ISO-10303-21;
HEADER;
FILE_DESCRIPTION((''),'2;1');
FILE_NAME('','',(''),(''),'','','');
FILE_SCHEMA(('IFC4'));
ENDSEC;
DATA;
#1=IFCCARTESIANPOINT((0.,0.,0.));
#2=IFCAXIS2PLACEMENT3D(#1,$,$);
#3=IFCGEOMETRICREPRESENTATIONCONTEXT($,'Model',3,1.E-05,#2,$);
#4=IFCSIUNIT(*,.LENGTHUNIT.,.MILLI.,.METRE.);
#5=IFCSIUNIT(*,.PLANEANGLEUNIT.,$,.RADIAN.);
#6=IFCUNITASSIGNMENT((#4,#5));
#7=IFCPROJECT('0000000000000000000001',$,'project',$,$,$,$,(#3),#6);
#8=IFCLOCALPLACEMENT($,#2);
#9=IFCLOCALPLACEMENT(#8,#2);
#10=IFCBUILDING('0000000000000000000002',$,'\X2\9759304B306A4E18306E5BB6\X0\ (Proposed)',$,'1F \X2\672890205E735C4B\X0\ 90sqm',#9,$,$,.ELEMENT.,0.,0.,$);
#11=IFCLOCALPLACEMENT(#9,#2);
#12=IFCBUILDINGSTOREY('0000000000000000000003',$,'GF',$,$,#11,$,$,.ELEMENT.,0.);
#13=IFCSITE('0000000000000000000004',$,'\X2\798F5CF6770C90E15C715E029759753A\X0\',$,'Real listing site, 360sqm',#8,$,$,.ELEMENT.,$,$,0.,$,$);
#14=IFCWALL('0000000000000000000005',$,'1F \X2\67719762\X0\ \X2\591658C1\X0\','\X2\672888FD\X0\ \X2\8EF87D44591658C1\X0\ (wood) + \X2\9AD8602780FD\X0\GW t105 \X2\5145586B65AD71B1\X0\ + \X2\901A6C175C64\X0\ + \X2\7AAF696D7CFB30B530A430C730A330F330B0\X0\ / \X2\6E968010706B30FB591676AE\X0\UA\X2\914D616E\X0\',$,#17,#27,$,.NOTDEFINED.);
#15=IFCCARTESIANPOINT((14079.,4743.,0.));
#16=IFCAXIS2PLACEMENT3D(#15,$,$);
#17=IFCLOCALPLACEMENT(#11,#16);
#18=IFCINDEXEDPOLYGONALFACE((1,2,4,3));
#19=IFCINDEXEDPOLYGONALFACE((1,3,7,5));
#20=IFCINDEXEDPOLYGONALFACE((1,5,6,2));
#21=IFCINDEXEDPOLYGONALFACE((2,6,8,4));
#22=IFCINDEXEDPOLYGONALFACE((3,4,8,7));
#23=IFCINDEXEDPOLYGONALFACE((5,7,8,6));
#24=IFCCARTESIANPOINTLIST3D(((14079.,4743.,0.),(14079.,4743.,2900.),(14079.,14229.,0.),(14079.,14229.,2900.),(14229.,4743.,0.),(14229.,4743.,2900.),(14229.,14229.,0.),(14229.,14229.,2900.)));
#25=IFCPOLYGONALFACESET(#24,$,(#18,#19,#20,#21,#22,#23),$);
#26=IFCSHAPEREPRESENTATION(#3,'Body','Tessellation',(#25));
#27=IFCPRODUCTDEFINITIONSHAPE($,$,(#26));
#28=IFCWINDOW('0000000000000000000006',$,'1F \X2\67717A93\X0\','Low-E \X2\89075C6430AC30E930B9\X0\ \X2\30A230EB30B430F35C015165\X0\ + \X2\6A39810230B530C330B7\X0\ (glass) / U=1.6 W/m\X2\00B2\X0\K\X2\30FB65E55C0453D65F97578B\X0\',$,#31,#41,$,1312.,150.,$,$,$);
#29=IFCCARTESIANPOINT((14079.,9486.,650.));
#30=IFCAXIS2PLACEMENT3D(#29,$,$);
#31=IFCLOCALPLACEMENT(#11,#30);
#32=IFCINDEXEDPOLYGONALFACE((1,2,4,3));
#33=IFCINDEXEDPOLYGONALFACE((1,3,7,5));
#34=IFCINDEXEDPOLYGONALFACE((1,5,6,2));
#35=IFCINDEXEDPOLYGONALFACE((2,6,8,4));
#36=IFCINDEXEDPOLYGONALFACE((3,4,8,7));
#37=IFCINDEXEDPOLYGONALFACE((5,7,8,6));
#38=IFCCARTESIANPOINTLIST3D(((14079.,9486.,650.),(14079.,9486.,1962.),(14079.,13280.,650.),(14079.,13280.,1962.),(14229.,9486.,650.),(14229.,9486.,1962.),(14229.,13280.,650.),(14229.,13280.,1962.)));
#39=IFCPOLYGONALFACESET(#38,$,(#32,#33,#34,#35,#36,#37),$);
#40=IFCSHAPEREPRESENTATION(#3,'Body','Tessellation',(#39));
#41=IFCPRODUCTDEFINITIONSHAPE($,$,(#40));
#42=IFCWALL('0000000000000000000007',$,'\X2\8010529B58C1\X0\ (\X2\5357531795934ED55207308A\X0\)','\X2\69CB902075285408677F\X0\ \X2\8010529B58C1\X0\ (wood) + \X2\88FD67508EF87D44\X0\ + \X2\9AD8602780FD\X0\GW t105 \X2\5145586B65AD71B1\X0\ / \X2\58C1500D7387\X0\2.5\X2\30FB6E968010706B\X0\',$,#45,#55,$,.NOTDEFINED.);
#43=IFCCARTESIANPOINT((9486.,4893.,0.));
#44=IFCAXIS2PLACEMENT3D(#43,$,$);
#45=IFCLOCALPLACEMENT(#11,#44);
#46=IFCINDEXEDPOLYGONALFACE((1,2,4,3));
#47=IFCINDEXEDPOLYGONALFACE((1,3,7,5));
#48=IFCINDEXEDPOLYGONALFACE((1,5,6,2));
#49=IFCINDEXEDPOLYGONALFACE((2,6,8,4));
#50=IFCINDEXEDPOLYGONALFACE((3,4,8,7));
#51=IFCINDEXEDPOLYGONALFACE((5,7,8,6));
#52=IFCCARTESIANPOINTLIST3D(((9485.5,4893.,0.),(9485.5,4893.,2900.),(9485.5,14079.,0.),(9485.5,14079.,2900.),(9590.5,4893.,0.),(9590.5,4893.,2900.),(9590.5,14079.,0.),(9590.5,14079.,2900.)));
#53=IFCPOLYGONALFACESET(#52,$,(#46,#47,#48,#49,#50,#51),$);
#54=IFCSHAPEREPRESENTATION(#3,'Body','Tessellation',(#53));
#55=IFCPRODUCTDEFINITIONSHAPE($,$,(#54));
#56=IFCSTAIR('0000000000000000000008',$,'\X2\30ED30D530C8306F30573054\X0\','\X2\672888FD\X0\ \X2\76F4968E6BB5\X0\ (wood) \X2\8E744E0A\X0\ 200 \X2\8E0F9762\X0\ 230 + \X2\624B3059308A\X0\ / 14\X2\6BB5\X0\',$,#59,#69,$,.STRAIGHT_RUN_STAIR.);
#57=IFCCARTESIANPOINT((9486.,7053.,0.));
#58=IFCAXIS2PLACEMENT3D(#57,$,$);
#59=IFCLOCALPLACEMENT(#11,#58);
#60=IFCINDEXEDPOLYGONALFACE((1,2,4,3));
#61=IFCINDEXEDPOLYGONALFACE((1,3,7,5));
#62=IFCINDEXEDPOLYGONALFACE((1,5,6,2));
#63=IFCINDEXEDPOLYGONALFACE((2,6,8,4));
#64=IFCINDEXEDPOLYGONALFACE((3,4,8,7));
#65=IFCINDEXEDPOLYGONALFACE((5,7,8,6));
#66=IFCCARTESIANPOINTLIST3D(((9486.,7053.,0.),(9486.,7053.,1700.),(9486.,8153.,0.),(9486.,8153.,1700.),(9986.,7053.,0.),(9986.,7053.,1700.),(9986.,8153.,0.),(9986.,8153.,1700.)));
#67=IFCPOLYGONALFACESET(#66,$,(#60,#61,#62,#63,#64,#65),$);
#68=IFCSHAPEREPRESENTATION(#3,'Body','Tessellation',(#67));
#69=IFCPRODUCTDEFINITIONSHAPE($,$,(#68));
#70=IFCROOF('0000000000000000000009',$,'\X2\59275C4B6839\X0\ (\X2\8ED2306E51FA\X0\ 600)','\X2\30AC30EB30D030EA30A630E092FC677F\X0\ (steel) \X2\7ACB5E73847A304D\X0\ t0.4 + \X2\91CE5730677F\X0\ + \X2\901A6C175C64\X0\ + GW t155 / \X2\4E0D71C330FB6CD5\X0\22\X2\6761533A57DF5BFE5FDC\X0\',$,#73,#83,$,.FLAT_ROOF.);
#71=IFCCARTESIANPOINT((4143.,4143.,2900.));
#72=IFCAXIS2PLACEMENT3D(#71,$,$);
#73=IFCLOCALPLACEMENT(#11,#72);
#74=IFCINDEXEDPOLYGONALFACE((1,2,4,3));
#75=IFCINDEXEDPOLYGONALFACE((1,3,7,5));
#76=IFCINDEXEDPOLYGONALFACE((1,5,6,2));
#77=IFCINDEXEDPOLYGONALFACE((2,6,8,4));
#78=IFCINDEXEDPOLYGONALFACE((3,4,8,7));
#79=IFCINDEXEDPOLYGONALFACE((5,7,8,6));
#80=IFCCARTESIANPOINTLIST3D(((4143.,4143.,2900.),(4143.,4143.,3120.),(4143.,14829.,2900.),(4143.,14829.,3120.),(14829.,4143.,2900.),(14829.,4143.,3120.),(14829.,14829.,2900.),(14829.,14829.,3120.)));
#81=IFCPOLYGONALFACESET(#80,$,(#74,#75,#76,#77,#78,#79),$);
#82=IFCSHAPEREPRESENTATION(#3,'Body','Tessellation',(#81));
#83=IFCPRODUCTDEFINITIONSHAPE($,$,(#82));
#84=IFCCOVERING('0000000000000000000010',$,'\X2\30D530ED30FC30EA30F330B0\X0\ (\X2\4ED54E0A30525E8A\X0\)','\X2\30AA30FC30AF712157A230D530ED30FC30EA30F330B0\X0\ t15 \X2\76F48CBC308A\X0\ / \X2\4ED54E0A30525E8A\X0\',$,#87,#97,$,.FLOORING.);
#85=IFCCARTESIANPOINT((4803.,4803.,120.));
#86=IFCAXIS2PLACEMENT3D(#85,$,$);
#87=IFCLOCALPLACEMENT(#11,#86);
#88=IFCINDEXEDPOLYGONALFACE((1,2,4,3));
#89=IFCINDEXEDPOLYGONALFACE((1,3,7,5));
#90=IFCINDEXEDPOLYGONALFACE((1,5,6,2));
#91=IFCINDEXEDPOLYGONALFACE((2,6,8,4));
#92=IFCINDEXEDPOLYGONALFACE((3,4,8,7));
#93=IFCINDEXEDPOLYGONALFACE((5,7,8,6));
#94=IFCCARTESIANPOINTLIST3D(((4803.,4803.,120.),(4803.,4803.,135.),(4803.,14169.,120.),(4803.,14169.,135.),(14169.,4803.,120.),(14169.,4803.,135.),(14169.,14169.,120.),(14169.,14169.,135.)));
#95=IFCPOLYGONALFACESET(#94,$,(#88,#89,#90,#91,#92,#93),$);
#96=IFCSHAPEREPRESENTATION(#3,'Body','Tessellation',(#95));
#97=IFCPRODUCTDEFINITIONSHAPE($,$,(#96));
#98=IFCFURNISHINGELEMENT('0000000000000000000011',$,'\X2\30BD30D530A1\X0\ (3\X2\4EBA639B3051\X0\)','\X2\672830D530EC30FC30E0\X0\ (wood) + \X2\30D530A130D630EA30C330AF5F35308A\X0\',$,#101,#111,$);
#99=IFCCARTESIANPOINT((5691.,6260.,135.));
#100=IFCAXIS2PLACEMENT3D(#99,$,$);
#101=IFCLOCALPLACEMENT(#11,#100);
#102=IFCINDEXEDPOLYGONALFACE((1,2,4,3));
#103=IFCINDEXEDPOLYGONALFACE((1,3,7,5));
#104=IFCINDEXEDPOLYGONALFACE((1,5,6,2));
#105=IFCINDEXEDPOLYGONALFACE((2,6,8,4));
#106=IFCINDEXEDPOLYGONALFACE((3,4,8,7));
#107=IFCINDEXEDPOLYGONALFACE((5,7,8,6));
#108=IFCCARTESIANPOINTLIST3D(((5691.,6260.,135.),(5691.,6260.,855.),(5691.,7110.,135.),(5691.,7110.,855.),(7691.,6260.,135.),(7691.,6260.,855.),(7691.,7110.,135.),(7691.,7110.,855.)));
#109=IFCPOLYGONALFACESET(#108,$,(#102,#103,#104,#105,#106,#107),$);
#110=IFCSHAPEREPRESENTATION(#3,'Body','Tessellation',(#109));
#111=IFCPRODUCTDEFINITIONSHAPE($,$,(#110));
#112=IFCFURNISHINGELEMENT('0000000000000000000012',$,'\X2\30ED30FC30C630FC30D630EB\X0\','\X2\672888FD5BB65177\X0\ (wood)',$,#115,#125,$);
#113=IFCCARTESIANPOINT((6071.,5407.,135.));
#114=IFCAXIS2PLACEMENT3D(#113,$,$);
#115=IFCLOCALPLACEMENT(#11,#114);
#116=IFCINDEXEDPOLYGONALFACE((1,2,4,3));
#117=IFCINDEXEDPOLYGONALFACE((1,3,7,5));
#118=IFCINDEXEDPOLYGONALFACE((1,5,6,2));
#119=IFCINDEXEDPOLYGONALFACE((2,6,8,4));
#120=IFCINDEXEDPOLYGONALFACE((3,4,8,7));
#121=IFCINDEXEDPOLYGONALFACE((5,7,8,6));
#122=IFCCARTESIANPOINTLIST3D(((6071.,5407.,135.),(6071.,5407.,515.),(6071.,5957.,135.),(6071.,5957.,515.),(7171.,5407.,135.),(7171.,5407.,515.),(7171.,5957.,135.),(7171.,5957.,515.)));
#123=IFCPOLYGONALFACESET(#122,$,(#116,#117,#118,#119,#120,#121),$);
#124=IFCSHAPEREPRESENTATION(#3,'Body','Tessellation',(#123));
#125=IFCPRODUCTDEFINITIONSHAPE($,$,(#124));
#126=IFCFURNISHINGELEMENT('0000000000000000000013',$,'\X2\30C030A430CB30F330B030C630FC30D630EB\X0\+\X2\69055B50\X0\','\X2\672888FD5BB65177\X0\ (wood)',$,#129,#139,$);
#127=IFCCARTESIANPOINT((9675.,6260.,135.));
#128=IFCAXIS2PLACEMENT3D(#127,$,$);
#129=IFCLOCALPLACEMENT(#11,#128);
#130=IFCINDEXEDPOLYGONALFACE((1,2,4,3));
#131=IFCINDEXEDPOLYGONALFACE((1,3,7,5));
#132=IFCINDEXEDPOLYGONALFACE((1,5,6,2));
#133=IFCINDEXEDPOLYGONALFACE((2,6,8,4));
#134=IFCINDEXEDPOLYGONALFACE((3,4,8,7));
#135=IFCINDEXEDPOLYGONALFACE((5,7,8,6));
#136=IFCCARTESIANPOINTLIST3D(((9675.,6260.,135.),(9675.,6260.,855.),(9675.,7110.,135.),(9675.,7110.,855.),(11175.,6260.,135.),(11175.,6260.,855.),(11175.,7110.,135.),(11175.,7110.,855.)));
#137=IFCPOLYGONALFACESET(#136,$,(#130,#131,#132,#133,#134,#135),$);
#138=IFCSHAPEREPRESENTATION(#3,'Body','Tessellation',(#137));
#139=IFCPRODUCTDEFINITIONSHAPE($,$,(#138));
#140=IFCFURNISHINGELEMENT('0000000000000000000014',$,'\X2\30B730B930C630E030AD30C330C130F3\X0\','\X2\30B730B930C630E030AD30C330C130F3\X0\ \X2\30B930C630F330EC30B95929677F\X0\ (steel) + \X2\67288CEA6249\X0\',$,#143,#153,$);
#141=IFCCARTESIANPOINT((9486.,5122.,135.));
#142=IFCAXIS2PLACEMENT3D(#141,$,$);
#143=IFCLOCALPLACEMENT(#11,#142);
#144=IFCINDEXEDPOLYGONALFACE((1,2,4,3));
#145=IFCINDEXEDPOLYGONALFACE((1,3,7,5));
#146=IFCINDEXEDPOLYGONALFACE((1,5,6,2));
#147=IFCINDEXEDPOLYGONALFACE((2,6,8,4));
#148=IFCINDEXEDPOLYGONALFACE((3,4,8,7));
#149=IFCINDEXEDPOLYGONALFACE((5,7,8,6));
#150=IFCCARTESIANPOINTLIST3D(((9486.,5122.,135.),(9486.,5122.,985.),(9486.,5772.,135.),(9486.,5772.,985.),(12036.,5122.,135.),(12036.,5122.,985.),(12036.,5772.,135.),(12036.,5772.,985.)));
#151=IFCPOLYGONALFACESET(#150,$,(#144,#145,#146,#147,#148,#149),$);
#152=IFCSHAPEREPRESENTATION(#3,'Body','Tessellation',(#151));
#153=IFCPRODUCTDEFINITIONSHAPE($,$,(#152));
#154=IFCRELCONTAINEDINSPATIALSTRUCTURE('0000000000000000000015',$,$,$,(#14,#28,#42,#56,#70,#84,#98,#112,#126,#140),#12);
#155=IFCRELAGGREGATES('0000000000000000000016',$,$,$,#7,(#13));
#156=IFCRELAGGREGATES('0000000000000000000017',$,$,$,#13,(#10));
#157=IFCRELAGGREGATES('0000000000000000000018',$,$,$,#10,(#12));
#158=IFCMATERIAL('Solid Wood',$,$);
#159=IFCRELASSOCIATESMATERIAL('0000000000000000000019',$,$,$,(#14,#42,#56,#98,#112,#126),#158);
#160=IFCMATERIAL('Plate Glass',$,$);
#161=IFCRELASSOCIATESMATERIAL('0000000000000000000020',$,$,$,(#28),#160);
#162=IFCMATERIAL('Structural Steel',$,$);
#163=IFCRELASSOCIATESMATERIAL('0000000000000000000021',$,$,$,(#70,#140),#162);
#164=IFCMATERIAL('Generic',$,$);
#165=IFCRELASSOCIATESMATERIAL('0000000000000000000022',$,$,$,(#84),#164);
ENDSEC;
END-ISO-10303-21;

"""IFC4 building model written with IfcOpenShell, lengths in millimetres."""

from ifc_helpers import new_model, si_unit, frame, frame_2d, origin, place, context, project, spatial, rectangle, extrude, material, element, fill, save


model = new_model("IFC4")

# Units and contexts
model_context = context("Model", 3, precision=1e-05, world=origin())
ifc_project = project(units=[si_unit("LENGTHUNIT", "METRE", prefix="MILLI"), si_unit("PLANEANGLEUNIT", "RADIAN")], contexts=[model_context])

# Site, building, storey
site_placement = place(None, origin())
site = spatial("IfcSite", under=ifc_project, at=site_placement, Name="福島県郡山市静町", ObjectType="Real listing site, 360sqm", CompositionType="ELEMENT", RefElevation=0.0)
building_placement = place(site_placement, origin())
building = spatial("IfcBuilding", under=site, at=building_placement, Name="静かな丘の家 (Proposed)", ObjectType="1F 木造平屋 90sqm", CompositionType="ELEMENT", ElevationOfRefHeight=0.0, ElevationOfTerrain=0.0)
storey_placement = place(building_placement, origin())
storey = spatial("IfcBuildingStorey", under=building, at=storey_placement, Name="GF", CompositionType="ELEMENT", Elevation=0.0)

# Shared definitions
ifc_material_1 = material(Name="Solid Wood")

# Shared definitions
ifc_material_2 = material(Name="Plate Glass")

# Wall, opening, window
wall_1_placement = place(storey_placement, frame((14079.0, 4743.0, 0.0)))
wall_1 = element("IfcWall", 1, at=wall_1_placement, inside=storey, material=ifc_material_1, Name="1F 東面 外壁", Description="木製 軸組外壁 (wood) + 高性能GW t105 充填断熱 + 通気層 + 窯業系サイディング / 準耐火・外皮UA配慮", PredefinedType="NOTDEFINED", context=model_context, shape_type="SweptSolid", body=[
    extrude(rectangle(XDim=150.0, YDim=9486.0, at=frame_2d((75.0, 4743.0))), frame((14079.0, 4743.0, 0.0)), (0.0, 0.0, 1.0), 2900.0),
])
opening_1_placement = place(storey_placement, frame((14079.0, 9486.0, 650.0)))
opening_1 = element("IfcOpeningElement", 2, at=opening_1_placement, cuts=wall_1, PredefinedType="NOTDEFINED", context=model_context, shape_type="SweptSolid", body=[
    extrude(rectangle(XDim=150.0, YDim=3794.0, at=frame_2d((75.0, 1897.0))), frame((14079.0, 9486.0, 650.0)), (0.0, 0.0, 1.0), 1312.0),
])
window_1_placement = place(storey_placement, frame((14079.0, 9486.0, 650.0)))
window_1 = element("IfcWindow", 3, at=window_1_placement, inside=storey, material=ifc_material_2, Name="1F 東窓", Description="Low-E 複層ガラス アルゴン封入 + 樹脂サッシ (glass) / U=1.6 W/m²K・日射取得型", OverallHeight=1312.0, OverallWidth=150.0, context=model_context, shape_type="SweptSolid", body=[
    extrude(rectangle(XDim=150.0, YDim=3794.0, at=frame_2d((75.0, 1897.0))), frame((14079.0, 9486.0, 650.0)), (0.0, 0.0, 1.0), 1312.0),
])
fill(opening_1, window_1)

# Wall
wall_2_placement = place(storey_placement, frame((9486.0, 4893.0, 0.0)))
element("IfcWall", 4, at=wall_2_placement, inside=storey, material=ifc_material_1, Name="耐力壁 (南北間仕切り)", Description="構造用合板 耐力壁 (wood) + 製材軸組 + 高性能GW t105 充填断熱 / 壁倍率2.5・準耐火", PredefinedType="NOTDEFINED", context=model_context, shape_type="SweptSolid", body=[
    extrude(rectangle(XDim=105.0, YDim=9186.0, at=frame_2d((52.0, 4593.0))), frame((9486.0, 4893.0, 0.0)), (0.0, 0.0, 1.0), 2900.0),
])

# Stair
stair_placement = place(storey_placement, frame((9486.0, 7053.0, 0.0)))
element("IfcStair", 5, at=stair_placement, inside=storey, material=ifc_material_1, Name="ロフトはしご", Description="木製 直階段 (wood) 蹴上 200 踏面 230 + 手すり / 14段", PredefinedType="STRAIGHT_RUN_STAIR", context=model_context, shape_type="SweptSolid", body=[
    extrude(rectangle(XDim=500.0, YDim=1100.0, at=frame_2d((250.0, 550.0))), frame((9486.0, 7053.0, 0.0)), (0.0, 0.0, 1.0), 1700.0),
])

# Roof
ifc_material_3 = material(Name="Structural Steel")
roof_placement = place(storey_placement, frame((4143.0, 4143.0, 2900.0)))
element("IfcRoof", 6, at=roof_placement, inside=storey, material=ifc_material_3, Name="大屋根 (軒の出 600)", Description="ガルバリウム鋼板 (steel) 立平葺き t0.4 + 野地板 + 通気層 + GW t155 / 不燃・法22条区域対応", PredefinedType="FLAT_ROOF", context=model_context, shape_type="SweptSolid", body=[
    extrude(rectangle(XDim=10686.0, YDim=10686.0, at=frame_2d((5343.0, 5343.0))), frame((4143.0, 4143.0, 2900.0)), (0.0, 0.0, 1.0), 220.0),
])

# Covering
ifc_material_4 = material(Name="Generic")
covering_placement = place(storey_placement, frame((4803.0, 4803.0, 120.0)))
element("IfcCovering", 7, at=covering_placement, inside=storey, material=ifc_material_4, Name="フローリング (仕上げ床)", Description="オーク無垢フローリング t15 直貼り / 仕上げ床", PredefinedType="FLOORING", context=model_context, shape_type="SweptSolid", body=[
    extrude(rectangle(XDim=9366.0, YDim=9366.0, at=frame_2d((4683.0, 4683.0))), frame((4803.0, 4803.0, 120.0)), (0.0, 0.0, 1.0), 15.0),
])

# Furnishing elements
furnishing_1_placement = place(storey_placement, frame((5691.0, 6260.0, 135.0)))
element("IfcFurnishingElement", 8, at=furnishing_1_placement, inside=storey, material=ifc_material_1, Name="ソファ (3人掛け)", Description="木フレーム (wood) + ファブリック張り", context=model_context, shape_type="SweptSolid", body=[
    extrude(rectangle(XDim=2000.0, YDim=850.0, at=frame_2d((1000.0, 425.0))), frame((5691.0, 6260.0, 135.0)), (0.0, 0.0, 1.0), 720.0),
])
furnishing_2_placement = place(storey_placement, frame((6071.0, 5407.0, 135.0)))
element("IfcFurnishingElement", 9, at=furnishing_2_placement, inside=storey, material=ifc_material_1, Name="ローテーブル", Description="木製家具 (wood)", context=model_context, shape_type="SweptSolid", body=[
    extrude(rectangle(XDim=1100.0, YDim=550.0, at=frame_2d((550.0, 275.0))), frame((6071.0, 5407.0, 135.0)), (0.0, 0.0, 1.0), 380.0),
])
furnishing_3_placement = place(storey_placement, frame((9675.0, 6260.0, 135.0)))
element("IfcFurnishingElement", 10, at=furnishing_3_placement, inside=storey, material=ifc_material_1, Name="ダイニングテーブル+椅子", Description="木製家具 (wood)", context=model_context, shape_type="SweptSolid", body=[
    extrude(rectangle(XDim=1500.0, YDim=850.0, at=frame_2d((750.0, 425.0))), frame((9675.0, 6260.0, 135.0)), (0.0, 0.0, 1.0), 720.0),
])
furnishing_4_placement = place(storey_placement, frame((9486.0, 5122.0, 135.0)))
element("IfcFurnishingElement", 11, at=furnishing_4_placement, inside=storey, material=ifc_material_3, Name="システムキッチン", Description="システムキッチン ステンレス天板 (steel) + 木質扉", context=model_context, shape_type="SweptSolid", body=[
    extrude(rectangle(XDim=2550.0, YDim=650.0, at=frame_2d((1275.0, 325.0))), frame((9486.0, 5122.0, 135.0)), (0.0, 0.0, 1.0), 850.0),
])

save(model, "model.ifc")
